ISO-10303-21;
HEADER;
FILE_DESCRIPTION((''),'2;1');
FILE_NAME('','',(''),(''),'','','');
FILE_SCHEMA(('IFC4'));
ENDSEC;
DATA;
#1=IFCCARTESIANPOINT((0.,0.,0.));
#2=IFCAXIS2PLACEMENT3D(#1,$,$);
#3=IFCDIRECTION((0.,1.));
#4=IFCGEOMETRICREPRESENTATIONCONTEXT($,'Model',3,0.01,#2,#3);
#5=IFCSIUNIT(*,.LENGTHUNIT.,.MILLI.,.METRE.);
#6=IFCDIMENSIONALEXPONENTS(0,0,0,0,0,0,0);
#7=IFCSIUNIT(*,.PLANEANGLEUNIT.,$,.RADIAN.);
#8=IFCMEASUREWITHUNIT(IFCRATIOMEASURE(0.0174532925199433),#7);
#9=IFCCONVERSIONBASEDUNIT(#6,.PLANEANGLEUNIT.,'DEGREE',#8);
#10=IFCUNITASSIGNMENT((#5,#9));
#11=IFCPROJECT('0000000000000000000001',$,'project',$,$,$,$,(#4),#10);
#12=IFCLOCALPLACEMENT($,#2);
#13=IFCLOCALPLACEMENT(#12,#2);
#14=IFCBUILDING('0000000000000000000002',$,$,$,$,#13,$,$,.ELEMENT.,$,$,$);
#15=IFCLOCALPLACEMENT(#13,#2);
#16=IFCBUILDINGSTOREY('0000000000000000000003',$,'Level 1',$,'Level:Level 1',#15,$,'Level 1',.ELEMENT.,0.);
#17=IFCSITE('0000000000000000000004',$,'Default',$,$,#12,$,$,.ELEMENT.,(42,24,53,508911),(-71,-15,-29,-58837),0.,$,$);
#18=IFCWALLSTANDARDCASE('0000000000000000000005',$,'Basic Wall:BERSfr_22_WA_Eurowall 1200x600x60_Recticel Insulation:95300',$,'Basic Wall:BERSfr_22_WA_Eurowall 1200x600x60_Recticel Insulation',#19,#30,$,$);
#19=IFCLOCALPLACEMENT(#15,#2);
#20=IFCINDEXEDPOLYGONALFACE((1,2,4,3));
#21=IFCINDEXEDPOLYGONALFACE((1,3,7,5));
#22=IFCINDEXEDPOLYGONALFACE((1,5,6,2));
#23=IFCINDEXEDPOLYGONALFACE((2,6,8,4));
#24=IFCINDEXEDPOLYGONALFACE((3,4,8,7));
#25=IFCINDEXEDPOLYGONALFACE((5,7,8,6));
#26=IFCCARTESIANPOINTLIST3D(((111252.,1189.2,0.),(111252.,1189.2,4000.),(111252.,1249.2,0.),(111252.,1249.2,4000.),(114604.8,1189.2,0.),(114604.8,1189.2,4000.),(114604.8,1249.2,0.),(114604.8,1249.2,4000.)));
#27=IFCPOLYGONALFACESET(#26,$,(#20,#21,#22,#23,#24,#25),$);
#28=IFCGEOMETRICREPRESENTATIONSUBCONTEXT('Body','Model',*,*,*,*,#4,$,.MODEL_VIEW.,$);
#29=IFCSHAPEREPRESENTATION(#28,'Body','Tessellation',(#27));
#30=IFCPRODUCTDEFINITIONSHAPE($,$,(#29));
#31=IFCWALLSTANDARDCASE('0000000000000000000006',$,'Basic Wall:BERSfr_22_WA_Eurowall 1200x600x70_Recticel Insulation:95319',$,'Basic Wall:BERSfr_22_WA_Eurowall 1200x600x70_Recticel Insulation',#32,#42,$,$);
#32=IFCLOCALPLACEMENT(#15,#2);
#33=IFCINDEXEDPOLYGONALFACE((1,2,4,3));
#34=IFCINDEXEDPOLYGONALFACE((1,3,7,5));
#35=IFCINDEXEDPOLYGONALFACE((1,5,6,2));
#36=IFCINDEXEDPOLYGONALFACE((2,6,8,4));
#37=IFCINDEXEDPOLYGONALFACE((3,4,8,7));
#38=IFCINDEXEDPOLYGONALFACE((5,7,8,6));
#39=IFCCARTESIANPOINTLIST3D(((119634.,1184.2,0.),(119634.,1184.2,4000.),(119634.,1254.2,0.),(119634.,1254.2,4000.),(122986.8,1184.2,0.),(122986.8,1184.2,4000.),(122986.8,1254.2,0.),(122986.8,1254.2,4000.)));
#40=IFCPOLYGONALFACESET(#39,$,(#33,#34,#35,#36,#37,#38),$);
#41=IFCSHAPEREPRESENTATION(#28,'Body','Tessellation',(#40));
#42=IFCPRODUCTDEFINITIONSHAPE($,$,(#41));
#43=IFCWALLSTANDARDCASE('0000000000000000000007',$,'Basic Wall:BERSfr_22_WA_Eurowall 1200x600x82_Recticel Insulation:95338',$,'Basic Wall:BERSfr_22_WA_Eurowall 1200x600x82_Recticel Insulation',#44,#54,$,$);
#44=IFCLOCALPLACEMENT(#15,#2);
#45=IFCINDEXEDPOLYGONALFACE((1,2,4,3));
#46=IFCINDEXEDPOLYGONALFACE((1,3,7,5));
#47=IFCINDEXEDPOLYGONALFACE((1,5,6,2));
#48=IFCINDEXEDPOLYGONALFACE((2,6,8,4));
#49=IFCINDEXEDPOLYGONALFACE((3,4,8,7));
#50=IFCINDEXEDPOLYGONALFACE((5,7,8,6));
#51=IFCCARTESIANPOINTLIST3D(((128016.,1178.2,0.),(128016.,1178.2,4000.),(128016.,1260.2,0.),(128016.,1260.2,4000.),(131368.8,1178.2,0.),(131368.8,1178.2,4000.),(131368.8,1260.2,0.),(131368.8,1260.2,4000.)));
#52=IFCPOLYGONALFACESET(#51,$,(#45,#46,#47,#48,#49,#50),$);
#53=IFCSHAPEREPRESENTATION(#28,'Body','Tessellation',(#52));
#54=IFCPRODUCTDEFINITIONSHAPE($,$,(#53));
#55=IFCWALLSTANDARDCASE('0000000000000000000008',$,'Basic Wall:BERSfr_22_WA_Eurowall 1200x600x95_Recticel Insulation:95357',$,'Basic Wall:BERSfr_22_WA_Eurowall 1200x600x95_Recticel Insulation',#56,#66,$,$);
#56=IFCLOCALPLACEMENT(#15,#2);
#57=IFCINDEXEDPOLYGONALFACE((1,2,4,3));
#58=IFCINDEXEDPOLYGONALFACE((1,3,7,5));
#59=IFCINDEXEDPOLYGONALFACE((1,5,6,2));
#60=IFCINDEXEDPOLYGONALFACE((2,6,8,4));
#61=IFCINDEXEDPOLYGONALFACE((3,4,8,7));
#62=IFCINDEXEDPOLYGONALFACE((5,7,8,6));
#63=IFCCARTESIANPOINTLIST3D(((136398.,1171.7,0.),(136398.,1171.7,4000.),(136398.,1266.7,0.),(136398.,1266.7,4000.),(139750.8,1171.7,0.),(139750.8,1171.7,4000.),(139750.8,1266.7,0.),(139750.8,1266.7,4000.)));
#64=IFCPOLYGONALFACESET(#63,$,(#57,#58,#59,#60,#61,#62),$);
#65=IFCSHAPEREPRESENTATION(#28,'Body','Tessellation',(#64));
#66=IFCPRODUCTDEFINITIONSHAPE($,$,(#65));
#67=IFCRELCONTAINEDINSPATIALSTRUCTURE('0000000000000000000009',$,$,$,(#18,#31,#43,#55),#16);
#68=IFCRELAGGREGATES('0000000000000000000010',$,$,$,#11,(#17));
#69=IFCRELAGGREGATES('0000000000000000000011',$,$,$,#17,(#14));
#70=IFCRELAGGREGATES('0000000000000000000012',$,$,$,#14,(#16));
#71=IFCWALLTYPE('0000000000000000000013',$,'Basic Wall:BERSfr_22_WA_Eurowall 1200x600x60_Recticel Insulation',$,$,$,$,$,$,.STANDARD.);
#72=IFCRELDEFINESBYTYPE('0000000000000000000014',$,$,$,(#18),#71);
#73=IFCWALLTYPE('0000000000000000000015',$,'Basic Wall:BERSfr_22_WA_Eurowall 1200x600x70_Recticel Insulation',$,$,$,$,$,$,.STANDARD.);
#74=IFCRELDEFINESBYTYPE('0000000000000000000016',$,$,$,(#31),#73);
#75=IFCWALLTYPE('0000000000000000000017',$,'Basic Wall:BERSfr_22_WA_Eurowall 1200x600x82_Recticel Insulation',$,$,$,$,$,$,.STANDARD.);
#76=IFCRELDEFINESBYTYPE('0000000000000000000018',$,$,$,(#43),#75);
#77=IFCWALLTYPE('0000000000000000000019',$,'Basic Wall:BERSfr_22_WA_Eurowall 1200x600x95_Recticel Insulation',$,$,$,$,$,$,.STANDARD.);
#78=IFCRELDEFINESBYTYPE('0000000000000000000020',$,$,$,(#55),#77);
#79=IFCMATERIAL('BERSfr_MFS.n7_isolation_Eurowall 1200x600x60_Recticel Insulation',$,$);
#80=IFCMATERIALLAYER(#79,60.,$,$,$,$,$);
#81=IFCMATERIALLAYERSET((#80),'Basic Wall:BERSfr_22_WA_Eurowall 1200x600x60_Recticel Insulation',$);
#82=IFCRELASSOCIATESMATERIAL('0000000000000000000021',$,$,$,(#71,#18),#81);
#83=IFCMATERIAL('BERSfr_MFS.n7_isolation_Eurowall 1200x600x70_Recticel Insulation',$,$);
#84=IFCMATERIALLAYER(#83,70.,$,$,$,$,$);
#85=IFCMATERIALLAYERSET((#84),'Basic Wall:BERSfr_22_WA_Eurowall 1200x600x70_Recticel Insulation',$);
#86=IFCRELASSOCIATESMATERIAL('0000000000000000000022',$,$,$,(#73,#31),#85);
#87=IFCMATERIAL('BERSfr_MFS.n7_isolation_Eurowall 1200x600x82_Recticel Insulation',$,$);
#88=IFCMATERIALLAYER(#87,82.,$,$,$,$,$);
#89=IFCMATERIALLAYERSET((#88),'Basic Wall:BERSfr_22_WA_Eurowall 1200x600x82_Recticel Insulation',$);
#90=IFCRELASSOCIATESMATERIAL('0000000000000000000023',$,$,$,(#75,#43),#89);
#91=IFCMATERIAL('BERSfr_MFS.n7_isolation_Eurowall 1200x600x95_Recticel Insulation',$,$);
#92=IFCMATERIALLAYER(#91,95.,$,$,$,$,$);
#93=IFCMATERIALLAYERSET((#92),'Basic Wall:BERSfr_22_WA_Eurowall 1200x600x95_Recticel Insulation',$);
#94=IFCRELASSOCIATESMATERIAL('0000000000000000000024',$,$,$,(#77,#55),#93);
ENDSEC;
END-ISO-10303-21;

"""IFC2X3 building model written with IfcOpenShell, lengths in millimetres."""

from ifc_helpers import new_model, entity, si_unit, converted_unit, direction, frame, frame_2d, origin, place, context, subcontext, project, spatial, rectangle, extrude, material, layer, layer_set, layer_usage, type_object, element, save


model = new_model("IFC2X3")

# Units and contexts
model_context = context("Model", 3, precision=0.01, world=origin(), true_north=direction((0.0, 1.0)))
body_context = subcontext(model_context, "Body", "Model", "MODEL_VIEW")
ifc_project = project(units=[si_unit("LENGTHUNIT", "METRE", prefix="MILLI"), converted_unit("PLANEANGLEUNIT", "DEGREE", entity("IfcRatioMeasure", 0.0174532925199433), si_unit("PLANEANGLEUNIT", "RADIAN"), dimensions=[0, 0, 0, 0, 0, 0, 0])], contexts=[model_context])

# Site, building, storey
site_placement = place(None, origin())
site = spatial("IfcSite", under=ifc_project, at=site_placement, Name="Default", CompositionType="ELEMENT", RefLatitude=(42, 24, 53, 508911), RefLongitude=(-71, -15, -29, -58837), RefElevation=0.0)
building_placement = place(site_placement, origin())
building = spatial("IfcBuilding", under=site, at=building_placement, CompositionType="ELEMENT")
storey_placement = place(building_placement, origin())
storey = spatial("IfcBuildingStorey", under=building, at=storey_placement, Name="Level 1", ObjectType="Level:Level 1", LongName="Level 1", CompositionType="ELEMENT", Elevation=0.0)

# Walls
ifc_material_1 = material(Name="BERSfr_MFS.n7_isolation_Eurowall 1200x600x60_Recticel Insulation")
ifc_layer_1 = layer(ifc_material_1, 60.0)
ifc_layer_set_1 = layer_set([ifc_layer_1], Name="Basic Wall:BERSfr_22_WA_Eurowall 1200x600x60_Recticel Insulation")
ifc_layer_usage_1 = layer_usage(ifc_layer_set_1, "AXIS2", "NEGATIVE", 30.0)
wall_type_1 = type_object("IfcWallType", Name="Basic Wall:BERSfr_22_WA_Eurowall 1200x600x60_Recticel Insulation", PredefinedType="STANDARD", material=ifc_layer_set_1)
wall_1_placement = place(storey_placement, frame((111252.0, 1219.2, 0.0)))
element("IfcWallStandardCase", 1, at=wall_1_placement, inside=storey, type_object=wall_type_1, material=ifc_layer_usage_1, Name="Basic Wall:BERSfr_22_WA_Eurowall 1200x600x60_Recticel Insulation:95300", ObjectType="Basic Wall:BERSfr_22_WA_Eurowall 1200x600x60_Recticel Insulation", context=body_context, shape_type="SweptSolid", body=[
    extrude(rectangle(XDim=3352.8, YDim=60.0, at=frame_2d((1676.4, 0.0), x_axis=(-1.0, 0.0))), origin(), (0.0, 0.0, 1.0), 4000.0),
])
ifc_material_2 = material(Name="BERSfr_MFS.n7_isolation_Eurowall 1200x600x70_Recticel Insulation")
ifc_layer_2 = layer(ifc_material_2, 70.0)
ifc_layer_set_2 = layer_set([ifc_layer_2], Name="Basic Wall:BERSfr_22_WA_Eurowall 1200x600x70_Recticel Insulation")
ifc_layer_usage_2 = layer_usage(ifc_layer_set_2, "AXIS2", "NEGATIVE", 35.0)
wall_type_2 = type_object("IfcWallType", Name="Basic Wall:BERSfr_22_WA_Eurowall 1200x600x70_Recticel Insulation", PredefinedType="STANDARD", material=ifc_layer_set_2)
wall_2_placement = place(storey_placement, frame((119634.0, 1219.2, 0.0)))
element("IfcWallStandardCase", 2, at=wall_2_placement, inside=storey, type_object=wall_type_2, material=ifc_layer_usage_2, Name="Basic Wall:BERSfr_22_WA_Eurowall 1200x600x70_Recticel Insulation:95319", ObjectType="Basic Wall:BERSfr_22_WA_Eurowall 1200x600x70_Recticel Insulation", context=body_context, shape_type="SweptSolid", body=[
    extrude(rectangle(XDim=3352.8, YDim=70.0, at=frame_2d((1676.4, 0.0), x_axis=(-1.0, 0.0))), origin(), (0.0, 0.0, 1.0), 4000.0),
])
ifc_material_3 = material(Name="BERSfr_MFS.n7_isolation_Eurowall 1200x600x82_Recticel Insulation")
ifc_layer_3 = layer(ifc_material_3, 82.0)
ifc_layer_set_3 = layer_set([ifc_layer_3], Name="Basic Wall:BERSfr_22_WA_Eurowall 1200x600x82_Recticel Insulation")
ifc_layer_usage_3 = layer_usage(ifc_layer_set_3, "AXIS2", "NEGATIVE", 41.0)
wall_type_3 = type_object("IfcWallType", Name="Basic Wall:BERSfr_22_WA_Eurowall 1200x600x82_Recticel Insulation", PredefinedType="STANDARD", material=ifc_layer_set_3)
wall_3_placement = place(storey_placement, frame((128016.0, 1219.2, 0.0)))
element("IfcWallStandardCase", 3, at=wall_3_placement, inside=storey, type_object=wall_type_3, material=ifc_layer_usage_3, Name="Basic Wall:BERSfr_22_WA_Eurowall 1200x600x82_Recticel Insulation:95338", ObjectType="Basic Wall:BERSfr_22_WA_Eurowall 1200x600x82_Recticel Insulation", context=body_context, shape_type="SweptSolid", body=[
    extrude(rectangle(XDim=3352.8, YDim=82.0, at=frame_2d((1676.4, 0.0), x_axis=(-1.0, 0.0))), origin(), (0.0, 0.0, 1.0), 4000.0),
])
ifc_material_4 = material(Name="BERSfr_MFS.n7_isolation_Eurowall 1200x600x95_Recticel Insulation")
ifc_layer_4 = layer(ifc_material_4, 95.0)
ifc_layer_set_4 = layer_set([ifc_layer_4], Name="Basic Wall:BERSfr_22_WA_Eurowall 1200x600x95_Recticel Insulation")
ifc_layer_usage_4 = layer_usage(ifc_layer_set_4, "AXIS2", "NEGATIVE", 47.5)
wall_type_4 = type_object("IfcWallType", Name="Basic Wall:BERSfr_22_WA_Eurowall 1200x600x95_Recticel Insulation", PredefinedType="STANDARD", material=ifc_layer_set_4)
wall_4_placement = place(storey_placement, frame((136398.0, 1219.2, 0.0)))
element("IfcWallStandardCase", 4, at=wall_4_placement, inside=storey, type_object=wall_type_4, material=ifc_layer_usage_4, Name="Basic Wall:BERSfr_22_WA_Eurowall 1200x600x95_Recticel Insulation:95357", ObjectType="Basic Wall:BERSfr_22_WA_Eurowall 1200x600x95_Recticel Insulation", context=body_context, shape_type="SweptSolid", body=[
    extrude(rectangle(XDim=3352.8, YDim=95.0, at=frame_2d((1676.4, 0.0), x_axis=(-1.0, 0.0))), origin(), (0.0, 0.0, 1.0), 4000.0),
])

save(model, "model.ifc")
